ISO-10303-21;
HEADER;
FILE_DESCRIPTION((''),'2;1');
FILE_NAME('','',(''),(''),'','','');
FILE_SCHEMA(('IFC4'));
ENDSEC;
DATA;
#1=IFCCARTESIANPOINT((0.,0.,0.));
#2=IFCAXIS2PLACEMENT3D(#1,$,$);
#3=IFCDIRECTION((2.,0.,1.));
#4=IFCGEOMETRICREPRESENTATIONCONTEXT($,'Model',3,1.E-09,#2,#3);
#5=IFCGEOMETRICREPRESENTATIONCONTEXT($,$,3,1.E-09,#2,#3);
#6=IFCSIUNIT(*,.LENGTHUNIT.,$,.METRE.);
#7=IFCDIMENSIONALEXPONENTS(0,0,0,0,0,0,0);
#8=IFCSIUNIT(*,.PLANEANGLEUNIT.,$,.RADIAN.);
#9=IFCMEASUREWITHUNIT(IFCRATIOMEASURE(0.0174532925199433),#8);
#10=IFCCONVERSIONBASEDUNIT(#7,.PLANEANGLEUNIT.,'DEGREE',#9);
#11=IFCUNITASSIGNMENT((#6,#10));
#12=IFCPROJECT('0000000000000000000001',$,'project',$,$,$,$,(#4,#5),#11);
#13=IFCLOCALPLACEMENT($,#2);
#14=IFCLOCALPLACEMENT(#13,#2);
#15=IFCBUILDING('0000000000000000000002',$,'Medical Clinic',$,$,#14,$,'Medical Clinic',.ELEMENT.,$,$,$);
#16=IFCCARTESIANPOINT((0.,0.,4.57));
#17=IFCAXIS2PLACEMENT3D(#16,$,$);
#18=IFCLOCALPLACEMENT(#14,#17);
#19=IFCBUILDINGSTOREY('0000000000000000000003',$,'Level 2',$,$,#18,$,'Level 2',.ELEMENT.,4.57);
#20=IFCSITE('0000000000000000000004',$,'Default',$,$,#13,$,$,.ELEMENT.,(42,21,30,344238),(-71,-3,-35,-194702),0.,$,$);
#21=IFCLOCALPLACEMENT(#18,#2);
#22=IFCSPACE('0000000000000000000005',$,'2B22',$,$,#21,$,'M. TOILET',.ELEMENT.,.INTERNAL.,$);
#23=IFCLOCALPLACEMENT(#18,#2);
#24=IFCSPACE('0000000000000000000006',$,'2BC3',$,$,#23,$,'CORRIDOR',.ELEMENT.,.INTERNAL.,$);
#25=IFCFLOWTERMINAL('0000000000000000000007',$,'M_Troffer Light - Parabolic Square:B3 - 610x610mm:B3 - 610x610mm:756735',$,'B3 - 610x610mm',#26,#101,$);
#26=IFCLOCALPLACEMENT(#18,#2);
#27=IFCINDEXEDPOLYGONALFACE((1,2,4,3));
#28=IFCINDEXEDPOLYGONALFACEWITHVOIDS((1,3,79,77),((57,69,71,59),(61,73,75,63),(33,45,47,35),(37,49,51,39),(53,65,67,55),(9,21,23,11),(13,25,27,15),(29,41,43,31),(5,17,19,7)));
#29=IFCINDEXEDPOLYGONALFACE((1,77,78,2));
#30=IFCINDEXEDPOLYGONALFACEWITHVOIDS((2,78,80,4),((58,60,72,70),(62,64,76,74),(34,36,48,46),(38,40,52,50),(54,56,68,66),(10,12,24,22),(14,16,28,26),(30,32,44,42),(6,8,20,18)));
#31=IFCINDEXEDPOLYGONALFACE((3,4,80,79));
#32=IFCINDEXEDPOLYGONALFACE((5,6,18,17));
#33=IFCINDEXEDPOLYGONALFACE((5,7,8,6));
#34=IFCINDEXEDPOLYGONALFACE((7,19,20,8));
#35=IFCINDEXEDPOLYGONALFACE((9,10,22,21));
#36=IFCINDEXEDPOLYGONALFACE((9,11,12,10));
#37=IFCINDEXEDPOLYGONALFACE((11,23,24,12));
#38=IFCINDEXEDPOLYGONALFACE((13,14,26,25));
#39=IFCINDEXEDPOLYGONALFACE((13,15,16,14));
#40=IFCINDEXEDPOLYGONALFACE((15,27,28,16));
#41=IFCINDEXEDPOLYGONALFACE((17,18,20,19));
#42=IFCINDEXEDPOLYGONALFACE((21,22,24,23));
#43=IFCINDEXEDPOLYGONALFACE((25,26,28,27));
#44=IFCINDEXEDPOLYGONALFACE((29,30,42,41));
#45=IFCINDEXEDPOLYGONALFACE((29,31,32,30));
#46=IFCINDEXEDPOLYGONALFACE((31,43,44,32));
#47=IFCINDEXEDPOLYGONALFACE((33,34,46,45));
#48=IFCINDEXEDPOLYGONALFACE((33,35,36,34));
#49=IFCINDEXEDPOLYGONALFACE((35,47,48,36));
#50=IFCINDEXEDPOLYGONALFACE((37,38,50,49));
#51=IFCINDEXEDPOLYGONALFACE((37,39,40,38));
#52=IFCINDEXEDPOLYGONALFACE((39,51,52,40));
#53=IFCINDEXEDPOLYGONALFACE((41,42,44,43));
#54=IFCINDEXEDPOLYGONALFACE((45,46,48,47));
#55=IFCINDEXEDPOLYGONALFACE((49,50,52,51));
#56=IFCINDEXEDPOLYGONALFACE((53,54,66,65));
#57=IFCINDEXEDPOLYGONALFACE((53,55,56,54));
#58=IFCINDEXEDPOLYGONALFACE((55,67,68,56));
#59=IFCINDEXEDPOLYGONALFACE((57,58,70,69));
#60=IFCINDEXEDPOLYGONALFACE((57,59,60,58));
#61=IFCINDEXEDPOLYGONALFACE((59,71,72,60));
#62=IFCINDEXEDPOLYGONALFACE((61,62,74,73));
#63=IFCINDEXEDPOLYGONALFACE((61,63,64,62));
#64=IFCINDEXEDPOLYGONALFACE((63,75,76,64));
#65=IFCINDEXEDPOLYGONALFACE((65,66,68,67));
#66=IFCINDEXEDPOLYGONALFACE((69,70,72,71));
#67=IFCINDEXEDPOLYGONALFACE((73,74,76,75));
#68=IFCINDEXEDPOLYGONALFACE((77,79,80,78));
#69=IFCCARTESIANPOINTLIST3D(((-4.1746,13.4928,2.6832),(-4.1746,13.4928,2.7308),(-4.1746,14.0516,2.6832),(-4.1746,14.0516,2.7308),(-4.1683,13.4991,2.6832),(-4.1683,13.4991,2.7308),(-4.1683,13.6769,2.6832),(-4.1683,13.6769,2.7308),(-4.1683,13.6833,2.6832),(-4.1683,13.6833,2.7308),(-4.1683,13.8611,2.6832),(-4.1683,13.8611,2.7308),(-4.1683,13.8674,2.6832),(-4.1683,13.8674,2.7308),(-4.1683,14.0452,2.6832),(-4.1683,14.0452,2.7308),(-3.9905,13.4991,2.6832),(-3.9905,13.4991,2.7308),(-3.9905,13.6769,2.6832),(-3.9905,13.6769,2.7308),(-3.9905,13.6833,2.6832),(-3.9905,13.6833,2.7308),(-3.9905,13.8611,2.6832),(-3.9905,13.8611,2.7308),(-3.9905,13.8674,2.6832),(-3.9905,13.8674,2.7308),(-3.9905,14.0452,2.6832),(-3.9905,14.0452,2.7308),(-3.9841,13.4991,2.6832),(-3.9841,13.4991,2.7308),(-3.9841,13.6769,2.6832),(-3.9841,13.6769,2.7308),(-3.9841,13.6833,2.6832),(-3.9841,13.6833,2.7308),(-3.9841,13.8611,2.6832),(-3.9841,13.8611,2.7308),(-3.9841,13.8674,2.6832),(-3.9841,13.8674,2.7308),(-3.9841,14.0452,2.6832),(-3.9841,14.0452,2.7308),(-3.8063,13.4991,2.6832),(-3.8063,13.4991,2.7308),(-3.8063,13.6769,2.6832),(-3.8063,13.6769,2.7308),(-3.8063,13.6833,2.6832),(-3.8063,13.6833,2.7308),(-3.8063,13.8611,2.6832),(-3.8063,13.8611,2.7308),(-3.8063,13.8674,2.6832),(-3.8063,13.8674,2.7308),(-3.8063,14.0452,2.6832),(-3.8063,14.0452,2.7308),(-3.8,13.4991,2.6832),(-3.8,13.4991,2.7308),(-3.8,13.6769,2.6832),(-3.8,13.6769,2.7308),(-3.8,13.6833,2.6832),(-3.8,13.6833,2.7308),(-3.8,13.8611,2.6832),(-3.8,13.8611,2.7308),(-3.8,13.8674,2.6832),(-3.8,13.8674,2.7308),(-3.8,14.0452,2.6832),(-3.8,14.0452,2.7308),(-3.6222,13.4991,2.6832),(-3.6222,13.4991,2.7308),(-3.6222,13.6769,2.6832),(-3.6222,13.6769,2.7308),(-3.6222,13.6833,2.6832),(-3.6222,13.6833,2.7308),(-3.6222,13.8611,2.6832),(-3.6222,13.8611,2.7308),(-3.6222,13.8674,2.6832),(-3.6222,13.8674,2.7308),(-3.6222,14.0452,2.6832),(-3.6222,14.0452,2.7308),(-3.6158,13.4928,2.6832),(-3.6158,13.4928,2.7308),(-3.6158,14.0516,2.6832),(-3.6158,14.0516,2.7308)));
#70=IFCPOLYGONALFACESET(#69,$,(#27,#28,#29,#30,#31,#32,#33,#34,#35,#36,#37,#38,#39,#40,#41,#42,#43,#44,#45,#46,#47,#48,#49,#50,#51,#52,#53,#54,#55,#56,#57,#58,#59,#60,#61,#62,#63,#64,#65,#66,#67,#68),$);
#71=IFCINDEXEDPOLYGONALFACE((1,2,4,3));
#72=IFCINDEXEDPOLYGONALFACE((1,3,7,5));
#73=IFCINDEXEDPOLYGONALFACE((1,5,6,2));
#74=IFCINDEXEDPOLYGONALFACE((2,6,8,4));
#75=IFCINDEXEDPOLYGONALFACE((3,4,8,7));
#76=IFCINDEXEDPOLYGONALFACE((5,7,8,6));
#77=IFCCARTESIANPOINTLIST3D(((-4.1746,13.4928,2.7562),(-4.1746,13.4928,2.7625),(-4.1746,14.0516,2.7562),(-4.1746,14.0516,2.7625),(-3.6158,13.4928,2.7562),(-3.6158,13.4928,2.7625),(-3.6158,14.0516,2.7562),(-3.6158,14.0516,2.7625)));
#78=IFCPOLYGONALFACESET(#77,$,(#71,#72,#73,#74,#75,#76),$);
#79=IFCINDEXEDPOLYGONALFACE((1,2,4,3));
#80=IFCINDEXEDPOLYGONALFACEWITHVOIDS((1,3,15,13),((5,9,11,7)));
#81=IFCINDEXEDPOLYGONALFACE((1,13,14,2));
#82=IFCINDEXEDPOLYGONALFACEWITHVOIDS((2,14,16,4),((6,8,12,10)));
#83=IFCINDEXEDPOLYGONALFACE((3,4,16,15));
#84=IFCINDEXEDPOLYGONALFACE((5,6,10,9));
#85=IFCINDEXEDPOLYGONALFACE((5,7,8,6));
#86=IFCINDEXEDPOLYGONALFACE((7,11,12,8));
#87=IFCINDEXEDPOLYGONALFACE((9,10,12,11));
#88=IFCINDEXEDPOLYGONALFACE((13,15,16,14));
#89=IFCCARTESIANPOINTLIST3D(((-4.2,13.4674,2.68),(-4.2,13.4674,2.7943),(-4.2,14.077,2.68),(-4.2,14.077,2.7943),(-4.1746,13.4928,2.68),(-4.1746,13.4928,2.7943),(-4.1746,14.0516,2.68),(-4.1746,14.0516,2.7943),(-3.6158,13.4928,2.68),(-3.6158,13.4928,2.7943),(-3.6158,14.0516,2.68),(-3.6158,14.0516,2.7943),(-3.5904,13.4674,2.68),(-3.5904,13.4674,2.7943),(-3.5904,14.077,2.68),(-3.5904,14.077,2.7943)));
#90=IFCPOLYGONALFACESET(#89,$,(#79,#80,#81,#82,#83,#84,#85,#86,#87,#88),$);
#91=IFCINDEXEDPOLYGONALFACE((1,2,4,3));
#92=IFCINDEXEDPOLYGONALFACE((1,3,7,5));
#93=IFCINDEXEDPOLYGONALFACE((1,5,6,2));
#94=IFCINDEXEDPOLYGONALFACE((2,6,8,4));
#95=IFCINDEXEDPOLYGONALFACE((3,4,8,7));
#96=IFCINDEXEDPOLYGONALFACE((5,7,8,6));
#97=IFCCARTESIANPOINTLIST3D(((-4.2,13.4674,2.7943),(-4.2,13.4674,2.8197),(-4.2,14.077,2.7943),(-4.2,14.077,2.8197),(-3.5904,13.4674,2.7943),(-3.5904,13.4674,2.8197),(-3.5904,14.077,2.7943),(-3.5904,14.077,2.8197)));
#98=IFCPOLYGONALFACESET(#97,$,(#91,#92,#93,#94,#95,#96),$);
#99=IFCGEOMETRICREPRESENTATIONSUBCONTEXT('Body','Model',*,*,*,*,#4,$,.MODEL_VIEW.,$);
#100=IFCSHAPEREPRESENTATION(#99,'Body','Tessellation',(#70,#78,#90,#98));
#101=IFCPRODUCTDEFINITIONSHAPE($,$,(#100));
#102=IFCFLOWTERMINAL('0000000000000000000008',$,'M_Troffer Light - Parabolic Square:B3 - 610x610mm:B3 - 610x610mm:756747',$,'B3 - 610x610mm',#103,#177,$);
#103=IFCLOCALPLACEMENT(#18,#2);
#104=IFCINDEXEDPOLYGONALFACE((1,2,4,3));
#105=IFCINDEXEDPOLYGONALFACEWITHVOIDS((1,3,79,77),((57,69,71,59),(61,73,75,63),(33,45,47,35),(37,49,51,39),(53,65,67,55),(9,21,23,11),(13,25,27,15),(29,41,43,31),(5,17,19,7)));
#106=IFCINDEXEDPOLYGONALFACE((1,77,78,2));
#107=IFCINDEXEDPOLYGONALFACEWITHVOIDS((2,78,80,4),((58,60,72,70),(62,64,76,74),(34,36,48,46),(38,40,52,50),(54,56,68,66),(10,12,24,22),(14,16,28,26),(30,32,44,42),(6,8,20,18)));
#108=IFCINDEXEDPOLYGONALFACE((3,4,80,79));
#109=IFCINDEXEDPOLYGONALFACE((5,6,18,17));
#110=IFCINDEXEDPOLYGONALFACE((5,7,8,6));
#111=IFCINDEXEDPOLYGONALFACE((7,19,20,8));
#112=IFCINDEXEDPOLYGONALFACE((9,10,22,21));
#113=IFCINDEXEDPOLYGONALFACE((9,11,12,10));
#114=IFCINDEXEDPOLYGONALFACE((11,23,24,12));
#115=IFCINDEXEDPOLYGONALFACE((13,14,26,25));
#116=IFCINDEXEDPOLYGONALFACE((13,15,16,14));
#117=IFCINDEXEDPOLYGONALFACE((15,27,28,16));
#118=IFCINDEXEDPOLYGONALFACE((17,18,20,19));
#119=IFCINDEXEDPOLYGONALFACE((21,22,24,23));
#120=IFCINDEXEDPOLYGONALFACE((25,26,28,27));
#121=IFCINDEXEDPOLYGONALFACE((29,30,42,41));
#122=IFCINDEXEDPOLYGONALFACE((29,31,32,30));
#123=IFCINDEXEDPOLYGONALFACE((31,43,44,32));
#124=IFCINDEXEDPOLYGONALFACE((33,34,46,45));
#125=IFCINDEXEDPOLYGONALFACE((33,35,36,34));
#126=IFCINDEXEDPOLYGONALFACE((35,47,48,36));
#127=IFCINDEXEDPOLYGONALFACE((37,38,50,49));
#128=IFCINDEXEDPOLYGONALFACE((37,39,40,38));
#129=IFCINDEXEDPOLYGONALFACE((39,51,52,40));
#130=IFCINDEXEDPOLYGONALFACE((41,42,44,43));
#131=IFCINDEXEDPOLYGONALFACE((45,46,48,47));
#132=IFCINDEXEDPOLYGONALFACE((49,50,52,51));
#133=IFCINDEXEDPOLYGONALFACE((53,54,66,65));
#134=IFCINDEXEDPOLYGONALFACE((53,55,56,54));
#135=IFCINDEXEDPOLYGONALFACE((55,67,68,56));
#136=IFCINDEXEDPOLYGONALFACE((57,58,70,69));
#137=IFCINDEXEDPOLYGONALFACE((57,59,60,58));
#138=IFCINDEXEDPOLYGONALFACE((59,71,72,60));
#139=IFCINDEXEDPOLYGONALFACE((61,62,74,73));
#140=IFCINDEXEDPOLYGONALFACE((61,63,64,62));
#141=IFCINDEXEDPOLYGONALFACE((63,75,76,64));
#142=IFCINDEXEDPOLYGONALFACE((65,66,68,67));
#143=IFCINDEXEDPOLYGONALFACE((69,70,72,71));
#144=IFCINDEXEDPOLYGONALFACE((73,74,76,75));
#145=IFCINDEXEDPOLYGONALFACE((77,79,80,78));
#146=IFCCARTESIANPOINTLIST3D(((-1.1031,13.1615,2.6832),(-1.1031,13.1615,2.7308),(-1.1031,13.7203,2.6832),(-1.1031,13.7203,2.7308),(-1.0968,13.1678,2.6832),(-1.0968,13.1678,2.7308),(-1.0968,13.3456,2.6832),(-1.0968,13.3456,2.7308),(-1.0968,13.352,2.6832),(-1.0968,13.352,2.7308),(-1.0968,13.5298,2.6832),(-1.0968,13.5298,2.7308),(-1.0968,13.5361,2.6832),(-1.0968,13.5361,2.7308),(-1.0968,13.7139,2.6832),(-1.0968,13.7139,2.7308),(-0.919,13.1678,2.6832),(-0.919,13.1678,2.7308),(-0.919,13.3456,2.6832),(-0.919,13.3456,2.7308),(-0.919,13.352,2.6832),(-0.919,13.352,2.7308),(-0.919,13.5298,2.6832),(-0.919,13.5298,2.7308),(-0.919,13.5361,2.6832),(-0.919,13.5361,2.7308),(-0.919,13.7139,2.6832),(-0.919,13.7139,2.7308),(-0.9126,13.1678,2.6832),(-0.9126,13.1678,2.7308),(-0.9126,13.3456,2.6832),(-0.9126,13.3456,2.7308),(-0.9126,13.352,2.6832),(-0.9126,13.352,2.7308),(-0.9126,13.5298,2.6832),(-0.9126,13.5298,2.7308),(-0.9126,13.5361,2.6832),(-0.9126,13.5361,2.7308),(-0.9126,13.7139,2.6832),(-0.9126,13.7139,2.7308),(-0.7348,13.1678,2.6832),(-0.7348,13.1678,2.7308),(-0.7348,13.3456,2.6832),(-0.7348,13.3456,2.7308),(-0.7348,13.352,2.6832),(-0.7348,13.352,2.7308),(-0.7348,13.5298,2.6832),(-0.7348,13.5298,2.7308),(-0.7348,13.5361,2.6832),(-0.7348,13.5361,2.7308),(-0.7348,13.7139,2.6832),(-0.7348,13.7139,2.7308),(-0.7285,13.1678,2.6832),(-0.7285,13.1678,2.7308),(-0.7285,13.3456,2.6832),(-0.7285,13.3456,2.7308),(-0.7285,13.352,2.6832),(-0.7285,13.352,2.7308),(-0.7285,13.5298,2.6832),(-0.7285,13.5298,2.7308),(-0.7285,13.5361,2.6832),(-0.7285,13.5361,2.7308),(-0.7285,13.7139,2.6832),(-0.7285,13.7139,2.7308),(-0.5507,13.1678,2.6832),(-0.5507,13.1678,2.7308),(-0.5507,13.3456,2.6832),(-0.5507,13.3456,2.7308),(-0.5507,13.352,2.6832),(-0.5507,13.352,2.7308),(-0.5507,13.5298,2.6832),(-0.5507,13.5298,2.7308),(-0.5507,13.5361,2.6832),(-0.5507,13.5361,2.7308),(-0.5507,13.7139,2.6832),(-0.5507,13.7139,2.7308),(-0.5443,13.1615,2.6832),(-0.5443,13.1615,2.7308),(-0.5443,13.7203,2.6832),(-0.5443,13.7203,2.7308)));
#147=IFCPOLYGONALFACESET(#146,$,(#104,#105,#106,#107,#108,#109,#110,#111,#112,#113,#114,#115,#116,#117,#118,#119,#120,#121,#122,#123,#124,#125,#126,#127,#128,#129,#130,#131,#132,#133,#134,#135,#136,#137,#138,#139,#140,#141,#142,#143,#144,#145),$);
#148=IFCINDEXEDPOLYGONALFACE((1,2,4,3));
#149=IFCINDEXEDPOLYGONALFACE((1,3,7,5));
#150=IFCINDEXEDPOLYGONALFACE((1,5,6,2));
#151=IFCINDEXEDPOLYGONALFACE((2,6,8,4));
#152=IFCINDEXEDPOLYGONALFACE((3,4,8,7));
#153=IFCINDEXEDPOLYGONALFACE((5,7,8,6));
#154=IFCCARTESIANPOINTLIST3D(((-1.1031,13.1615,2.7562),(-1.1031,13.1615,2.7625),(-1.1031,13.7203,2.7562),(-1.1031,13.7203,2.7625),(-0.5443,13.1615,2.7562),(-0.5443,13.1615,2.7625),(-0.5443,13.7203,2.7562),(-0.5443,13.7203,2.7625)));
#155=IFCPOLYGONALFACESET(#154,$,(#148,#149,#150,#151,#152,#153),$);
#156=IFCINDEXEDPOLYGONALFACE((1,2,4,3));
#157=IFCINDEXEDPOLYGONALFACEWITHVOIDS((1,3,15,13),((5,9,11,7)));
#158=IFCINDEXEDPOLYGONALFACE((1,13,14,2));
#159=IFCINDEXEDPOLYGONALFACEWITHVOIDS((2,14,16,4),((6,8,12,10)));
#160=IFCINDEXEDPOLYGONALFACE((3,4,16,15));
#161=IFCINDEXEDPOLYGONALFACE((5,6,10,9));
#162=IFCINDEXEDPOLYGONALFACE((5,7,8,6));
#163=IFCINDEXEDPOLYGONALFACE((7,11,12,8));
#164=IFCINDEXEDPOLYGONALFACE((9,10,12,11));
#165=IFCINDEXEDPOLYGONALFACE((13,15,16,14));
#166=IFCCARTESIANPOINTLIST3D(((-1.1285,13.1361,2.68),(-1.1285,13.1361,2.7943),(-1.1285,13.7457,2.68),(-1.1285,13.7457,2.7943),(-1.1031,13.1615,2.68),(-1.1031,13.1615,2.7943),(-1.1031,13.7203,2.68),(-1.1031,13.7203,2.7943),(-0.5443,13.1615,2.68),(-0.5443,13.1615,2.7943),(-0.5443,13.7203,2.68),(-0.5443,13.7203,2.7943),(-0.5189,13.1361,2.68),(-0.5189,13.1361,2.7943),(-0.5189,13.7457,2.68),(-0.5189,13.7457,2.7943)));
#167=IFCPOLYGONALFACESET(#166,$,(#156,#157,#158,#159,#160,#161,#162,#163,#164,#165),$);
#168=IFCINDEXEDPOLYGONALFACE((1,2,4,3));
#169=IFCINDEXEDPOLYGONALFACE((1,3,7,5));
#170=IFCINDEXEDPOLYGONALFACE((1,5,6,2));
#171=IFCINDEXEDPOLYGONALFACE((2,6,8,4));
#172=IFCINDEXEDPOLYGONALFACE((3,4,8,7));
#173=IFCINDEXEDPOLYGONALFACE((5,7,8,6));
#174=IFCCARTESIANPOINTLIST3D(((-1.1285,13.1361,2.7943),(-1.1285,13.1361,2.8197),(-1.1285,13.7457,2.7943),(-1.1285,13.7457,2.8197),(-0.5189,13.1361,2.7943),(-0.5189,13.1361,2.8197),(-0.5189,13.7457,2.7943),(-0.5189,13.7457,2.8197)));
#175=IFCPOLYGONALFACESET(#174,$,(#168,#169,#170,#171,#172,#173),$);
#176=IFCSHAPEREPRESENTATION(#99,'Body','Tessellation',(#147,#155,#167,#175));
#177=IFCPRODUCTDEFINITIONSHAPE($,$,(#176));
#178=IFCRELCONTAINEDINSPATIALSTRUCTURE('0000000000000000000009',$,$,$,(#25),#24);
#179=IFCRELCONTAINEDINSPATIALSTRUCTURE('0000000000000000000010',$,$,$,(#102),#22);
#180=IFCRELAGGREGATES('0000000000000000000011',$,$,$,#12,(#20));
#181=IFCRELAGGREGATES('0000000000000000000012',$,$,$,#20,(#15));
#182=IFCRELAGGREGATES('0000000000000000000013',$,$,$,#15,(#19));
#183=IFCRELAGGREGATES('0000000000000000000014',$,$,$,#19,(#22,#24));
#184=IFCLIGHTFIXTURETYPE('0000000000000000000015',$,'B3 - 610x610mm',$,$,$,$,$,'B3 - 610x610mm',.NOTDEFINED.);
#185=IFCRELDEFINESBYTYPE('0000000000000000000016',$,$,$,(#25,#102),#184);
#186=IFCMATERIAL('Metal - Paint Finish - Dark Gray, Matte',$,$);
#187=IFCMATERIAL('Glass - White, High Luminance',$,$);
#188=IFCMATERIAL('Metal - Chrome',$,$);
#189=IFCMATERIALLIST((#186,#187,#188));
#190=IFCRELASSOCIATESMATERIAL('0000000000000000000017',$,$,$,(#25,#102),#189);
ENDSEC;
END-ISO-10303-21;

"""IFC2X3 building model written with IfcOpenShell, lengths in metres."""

from ifc_helpers import new_model, entity, si_unit, converted_unit, direction, frame, origin, origin_2d_with_axis, place, context, subcontext, project, spatial, polyline, rectangle, outline, extrude, source, transform, mapped, material, material_list, type_object, type_shapes, element, save


model = new_model("IFC2X3")

# Units and contexts
model_context = context("Model", 3, precision=1e-09, world=origin(), true_north=direction((2.0, 0.0, 1.0)))
context_of_model = context(None, 3, precision=1e-09, world=origin(), true_north=direction((2.0, 0.0, 1.0)))
body_context = subcontext(model_context, "Body", "Model", "MODEL_VIEW")
ifc_project = project(units=[si_unit("LENGTHUNIT", "METRE"), converted_unit("PLANEANGLEUNIT", "DEGREE", entity("IfcRatioMeasure", 0.0174532925199433), si_unit("PLANEANGLEUNIT", "RADIAN"), dimensions=[0, 0, 0, 0, 0, 0, 0])], contexts=[model_context, context_of_model])

# Site, building, storey
site_placement = place(None, origin())
site = spatial("IfcSite", under=ifc_project, at=site_placement, Name="Default", CompositionType="ELEMENT", RefLatitude=(42, 21, 30, 344238), RefLongitude=(-71, -3, -35, -194702), RefElevation=0.0)
building_placement = place(site_placement, origin())
building = spatial("IfcBuilding", under=site, at=building_placement, Name="Medical Clinic", LongName="Medical Clinic", CompositionType="ELEMENT")
storey_placement = place(building_placement, frame((0.0, 0.0, 4.57)))
storey = spatial("IfcBuildingStorey", under=building, at=storey_placement, Name="Level 2", LongName="Level 2", CompositionType="ELEMENT", Elevation=4.57)

# Shared definitions
space_1_placement = place(storey_placement, origin())
space_1 = spatial("IfcSpace", under=storey, at=space_1_placement, Name="2B22", LongName="M. TOILET", CompositionType="ELEMENT", InteriorOrExteriorSpace="INTERNAL")

# Shared definitions
space_2_placement = place(storey_placement, origin())
space_2 = spatial("IfcSpace", under=storey, at=space_2_placement, Name="2BC3", LongName="CORRIDOR", CompositionType="ELEMENT", InteriorOrExteriorSpace="INTERNAL")

# Flow terminals
ifc_material_1 = material(Name="Metal - Paint Finish - Dark Gray, Matte")
ifc_material_2 = material(Name="Glass - White, High Luminance")
ifc_material_3 = material(Name="Metal - Chrome")
ifc_material_list_1 = material_list([ifc_material_1, ifc_material_2, ifc_material_3])
light_fixture_type_1 = type_object("IfcLightFixtureType", Name="B3 - 610x610mm", ElementType="B3 - 610x610mm", PredefinedType="NOTDEFINED")
shared_shape_1 = source(origin(), body_context, "Body", "SweptSolid", [
    extrude(outline(polyline([(-0.2794, -0.2794), (0.2794, -0.2794), (0.2794, 0.2794), (-0.2794, 0.2794), (-0.2794, -0.2794)]), holes=[polyline([(-0.0952, 0.0953), (-0.273, 0.0953), (-0.273, 0.2731), (-0.0952, 0.2731), (-0.0952, 0.0953)]), polyline([(0.2731, 0.0953), (0.0953, 0.0953), (0.0953, 0.2731), (0.2731, 0.2731), (0.2731, 0.0953)]), polyline([(-0.0889, 0.2731), (0.0889, 0.2731), (0.0889, 0.0953), (-0.0889, 0.0953), (-0.0889, 0.2731)]), polyline([(0.2731, -0.273), (0.0953, -0.273), (0.0953, -0.0952), (0.2731, -0.0952), (0.2731, -0.273)]), polyline([(0.0889, -0.273), (-0.0889, -0.273), (-0.0889, -0.0952), (0.0889, -0.0952), (0.0889, -0.273)]), polyline([(-0.0952, -0.273), (-0.273, -0.273), (-0.273, -0.0952), (-0.0952, -0.0952), (-0.0952, -0.273)]), polyline([(-0.0952, -0.0889), (-0.273, -0.0889), (-0.273, 0.0889), (-0.0952, 0.0889), (-0.0952, -0.0889)]), polyline([(0.0889, -0.0889), (-0.0889, -0.0889), (-0.0889, 0.0889), (0.0889, 0.0889), (0.0889, -0.0889)]), polyline([(0.2731, -0.0889), (0.0953, -0.0889), (0.0953, 0.0889), (0.2731, 0.0889), (0.2731, -0.0889)])]), frame((0.0, -0.3048, -0.0508), z_axis=(0.0, 0.0, 1.0), x_axis=(-1.0, 0.0, 0.0)), (0.0, 0.0, 1.0), 0.0476),
    extrude(rectangle(XDim=0.5588, YDim=0.5588, at=origin_2d_with_axis()), frame((0.0, -0.3048, -0.0825), z_axis=(0.0, 0.0, 1.0), x_axis=(-1.0, 0.0, 0.0)), (0.0, 0.0, 1.0), 0.0064),
    extrude(outline(polyline([(-0.3048, -0.3048), (0.3048, -0.3048), (0.3048, 0.3048), (-0.3048, 0.3048), (-0.3048, -0.3048)]), holes=[polyline([(0.2794, 0.2794), (0.2794, -0.2794), (-0.2794, -0.2794), (-0.2794, 0.2794), (0.2794, 0.2794)])]), frame((0.0, -0.3048, -0.1143)), (0.0, 0.0, 1.0), 0.1143),
    extrude(rectangle(XDim=0.6096, YDim=0.6096, at=origin_2d_with_axis()), frame((0.0, -0.3048, -0.1397), z_axis=(0.0, 0.0, 1.0), x_axis=(-1.0, 0.0, 0.0)), (0.0, 0.0, 1.0), 0.0254),
])
type_shapes(light_fixture_type_1, [shared_shape_1])
flow_terminal_1_placement = place(space_2_placement, frame((-3.8952, 13.4674, 2.68), z_axis=(0.0, 0.0, -1.0), x_axis=(1.0, 0.0, 0.0)))
element("IfcFlowTerminal", 1, at=flow_terminal_1_placement, inside=space_2, type_object=light_fixture_type_1, material=ifc_material_list_1, Name="M_Troffer Light - Parabolic Square:B3 - 610x610mm:B3 - 610x610mm:756735", ObjectType="B3 - 610x610mm", context=body_context, shape_type="MappedRepresentation", body=[
    mapped(shared_shape_1, transform((0.0, 0.0, 0.0), scale=1.0)),
])
flow_terminal_2_placement = place(space_1_placement, frame((-0.8237, 13.1361, 2.68), z_axis=(0.0, 0.0, -1.0), x_axis=(1.0, 0.0, 0.0)))
element("IfcFlowTerminal", 2, at=flow_terminal_2_placement, inside=space_1, type_object=light_fixture_type_1, material=ifc_material_list_1, Name="M_Troffer Light - Parabolic Square:B3 - 610x610mm:B3 - 610x610mm:756747", ObjectType="B3 - 610x610mm", context=body_context, shape_type="MappedRepresentation", body=[
    mapped(shared_shape_1, transform((0.0, 0.0, 0.0), scale=1.0)),
])

save(model, "model.ifc")
